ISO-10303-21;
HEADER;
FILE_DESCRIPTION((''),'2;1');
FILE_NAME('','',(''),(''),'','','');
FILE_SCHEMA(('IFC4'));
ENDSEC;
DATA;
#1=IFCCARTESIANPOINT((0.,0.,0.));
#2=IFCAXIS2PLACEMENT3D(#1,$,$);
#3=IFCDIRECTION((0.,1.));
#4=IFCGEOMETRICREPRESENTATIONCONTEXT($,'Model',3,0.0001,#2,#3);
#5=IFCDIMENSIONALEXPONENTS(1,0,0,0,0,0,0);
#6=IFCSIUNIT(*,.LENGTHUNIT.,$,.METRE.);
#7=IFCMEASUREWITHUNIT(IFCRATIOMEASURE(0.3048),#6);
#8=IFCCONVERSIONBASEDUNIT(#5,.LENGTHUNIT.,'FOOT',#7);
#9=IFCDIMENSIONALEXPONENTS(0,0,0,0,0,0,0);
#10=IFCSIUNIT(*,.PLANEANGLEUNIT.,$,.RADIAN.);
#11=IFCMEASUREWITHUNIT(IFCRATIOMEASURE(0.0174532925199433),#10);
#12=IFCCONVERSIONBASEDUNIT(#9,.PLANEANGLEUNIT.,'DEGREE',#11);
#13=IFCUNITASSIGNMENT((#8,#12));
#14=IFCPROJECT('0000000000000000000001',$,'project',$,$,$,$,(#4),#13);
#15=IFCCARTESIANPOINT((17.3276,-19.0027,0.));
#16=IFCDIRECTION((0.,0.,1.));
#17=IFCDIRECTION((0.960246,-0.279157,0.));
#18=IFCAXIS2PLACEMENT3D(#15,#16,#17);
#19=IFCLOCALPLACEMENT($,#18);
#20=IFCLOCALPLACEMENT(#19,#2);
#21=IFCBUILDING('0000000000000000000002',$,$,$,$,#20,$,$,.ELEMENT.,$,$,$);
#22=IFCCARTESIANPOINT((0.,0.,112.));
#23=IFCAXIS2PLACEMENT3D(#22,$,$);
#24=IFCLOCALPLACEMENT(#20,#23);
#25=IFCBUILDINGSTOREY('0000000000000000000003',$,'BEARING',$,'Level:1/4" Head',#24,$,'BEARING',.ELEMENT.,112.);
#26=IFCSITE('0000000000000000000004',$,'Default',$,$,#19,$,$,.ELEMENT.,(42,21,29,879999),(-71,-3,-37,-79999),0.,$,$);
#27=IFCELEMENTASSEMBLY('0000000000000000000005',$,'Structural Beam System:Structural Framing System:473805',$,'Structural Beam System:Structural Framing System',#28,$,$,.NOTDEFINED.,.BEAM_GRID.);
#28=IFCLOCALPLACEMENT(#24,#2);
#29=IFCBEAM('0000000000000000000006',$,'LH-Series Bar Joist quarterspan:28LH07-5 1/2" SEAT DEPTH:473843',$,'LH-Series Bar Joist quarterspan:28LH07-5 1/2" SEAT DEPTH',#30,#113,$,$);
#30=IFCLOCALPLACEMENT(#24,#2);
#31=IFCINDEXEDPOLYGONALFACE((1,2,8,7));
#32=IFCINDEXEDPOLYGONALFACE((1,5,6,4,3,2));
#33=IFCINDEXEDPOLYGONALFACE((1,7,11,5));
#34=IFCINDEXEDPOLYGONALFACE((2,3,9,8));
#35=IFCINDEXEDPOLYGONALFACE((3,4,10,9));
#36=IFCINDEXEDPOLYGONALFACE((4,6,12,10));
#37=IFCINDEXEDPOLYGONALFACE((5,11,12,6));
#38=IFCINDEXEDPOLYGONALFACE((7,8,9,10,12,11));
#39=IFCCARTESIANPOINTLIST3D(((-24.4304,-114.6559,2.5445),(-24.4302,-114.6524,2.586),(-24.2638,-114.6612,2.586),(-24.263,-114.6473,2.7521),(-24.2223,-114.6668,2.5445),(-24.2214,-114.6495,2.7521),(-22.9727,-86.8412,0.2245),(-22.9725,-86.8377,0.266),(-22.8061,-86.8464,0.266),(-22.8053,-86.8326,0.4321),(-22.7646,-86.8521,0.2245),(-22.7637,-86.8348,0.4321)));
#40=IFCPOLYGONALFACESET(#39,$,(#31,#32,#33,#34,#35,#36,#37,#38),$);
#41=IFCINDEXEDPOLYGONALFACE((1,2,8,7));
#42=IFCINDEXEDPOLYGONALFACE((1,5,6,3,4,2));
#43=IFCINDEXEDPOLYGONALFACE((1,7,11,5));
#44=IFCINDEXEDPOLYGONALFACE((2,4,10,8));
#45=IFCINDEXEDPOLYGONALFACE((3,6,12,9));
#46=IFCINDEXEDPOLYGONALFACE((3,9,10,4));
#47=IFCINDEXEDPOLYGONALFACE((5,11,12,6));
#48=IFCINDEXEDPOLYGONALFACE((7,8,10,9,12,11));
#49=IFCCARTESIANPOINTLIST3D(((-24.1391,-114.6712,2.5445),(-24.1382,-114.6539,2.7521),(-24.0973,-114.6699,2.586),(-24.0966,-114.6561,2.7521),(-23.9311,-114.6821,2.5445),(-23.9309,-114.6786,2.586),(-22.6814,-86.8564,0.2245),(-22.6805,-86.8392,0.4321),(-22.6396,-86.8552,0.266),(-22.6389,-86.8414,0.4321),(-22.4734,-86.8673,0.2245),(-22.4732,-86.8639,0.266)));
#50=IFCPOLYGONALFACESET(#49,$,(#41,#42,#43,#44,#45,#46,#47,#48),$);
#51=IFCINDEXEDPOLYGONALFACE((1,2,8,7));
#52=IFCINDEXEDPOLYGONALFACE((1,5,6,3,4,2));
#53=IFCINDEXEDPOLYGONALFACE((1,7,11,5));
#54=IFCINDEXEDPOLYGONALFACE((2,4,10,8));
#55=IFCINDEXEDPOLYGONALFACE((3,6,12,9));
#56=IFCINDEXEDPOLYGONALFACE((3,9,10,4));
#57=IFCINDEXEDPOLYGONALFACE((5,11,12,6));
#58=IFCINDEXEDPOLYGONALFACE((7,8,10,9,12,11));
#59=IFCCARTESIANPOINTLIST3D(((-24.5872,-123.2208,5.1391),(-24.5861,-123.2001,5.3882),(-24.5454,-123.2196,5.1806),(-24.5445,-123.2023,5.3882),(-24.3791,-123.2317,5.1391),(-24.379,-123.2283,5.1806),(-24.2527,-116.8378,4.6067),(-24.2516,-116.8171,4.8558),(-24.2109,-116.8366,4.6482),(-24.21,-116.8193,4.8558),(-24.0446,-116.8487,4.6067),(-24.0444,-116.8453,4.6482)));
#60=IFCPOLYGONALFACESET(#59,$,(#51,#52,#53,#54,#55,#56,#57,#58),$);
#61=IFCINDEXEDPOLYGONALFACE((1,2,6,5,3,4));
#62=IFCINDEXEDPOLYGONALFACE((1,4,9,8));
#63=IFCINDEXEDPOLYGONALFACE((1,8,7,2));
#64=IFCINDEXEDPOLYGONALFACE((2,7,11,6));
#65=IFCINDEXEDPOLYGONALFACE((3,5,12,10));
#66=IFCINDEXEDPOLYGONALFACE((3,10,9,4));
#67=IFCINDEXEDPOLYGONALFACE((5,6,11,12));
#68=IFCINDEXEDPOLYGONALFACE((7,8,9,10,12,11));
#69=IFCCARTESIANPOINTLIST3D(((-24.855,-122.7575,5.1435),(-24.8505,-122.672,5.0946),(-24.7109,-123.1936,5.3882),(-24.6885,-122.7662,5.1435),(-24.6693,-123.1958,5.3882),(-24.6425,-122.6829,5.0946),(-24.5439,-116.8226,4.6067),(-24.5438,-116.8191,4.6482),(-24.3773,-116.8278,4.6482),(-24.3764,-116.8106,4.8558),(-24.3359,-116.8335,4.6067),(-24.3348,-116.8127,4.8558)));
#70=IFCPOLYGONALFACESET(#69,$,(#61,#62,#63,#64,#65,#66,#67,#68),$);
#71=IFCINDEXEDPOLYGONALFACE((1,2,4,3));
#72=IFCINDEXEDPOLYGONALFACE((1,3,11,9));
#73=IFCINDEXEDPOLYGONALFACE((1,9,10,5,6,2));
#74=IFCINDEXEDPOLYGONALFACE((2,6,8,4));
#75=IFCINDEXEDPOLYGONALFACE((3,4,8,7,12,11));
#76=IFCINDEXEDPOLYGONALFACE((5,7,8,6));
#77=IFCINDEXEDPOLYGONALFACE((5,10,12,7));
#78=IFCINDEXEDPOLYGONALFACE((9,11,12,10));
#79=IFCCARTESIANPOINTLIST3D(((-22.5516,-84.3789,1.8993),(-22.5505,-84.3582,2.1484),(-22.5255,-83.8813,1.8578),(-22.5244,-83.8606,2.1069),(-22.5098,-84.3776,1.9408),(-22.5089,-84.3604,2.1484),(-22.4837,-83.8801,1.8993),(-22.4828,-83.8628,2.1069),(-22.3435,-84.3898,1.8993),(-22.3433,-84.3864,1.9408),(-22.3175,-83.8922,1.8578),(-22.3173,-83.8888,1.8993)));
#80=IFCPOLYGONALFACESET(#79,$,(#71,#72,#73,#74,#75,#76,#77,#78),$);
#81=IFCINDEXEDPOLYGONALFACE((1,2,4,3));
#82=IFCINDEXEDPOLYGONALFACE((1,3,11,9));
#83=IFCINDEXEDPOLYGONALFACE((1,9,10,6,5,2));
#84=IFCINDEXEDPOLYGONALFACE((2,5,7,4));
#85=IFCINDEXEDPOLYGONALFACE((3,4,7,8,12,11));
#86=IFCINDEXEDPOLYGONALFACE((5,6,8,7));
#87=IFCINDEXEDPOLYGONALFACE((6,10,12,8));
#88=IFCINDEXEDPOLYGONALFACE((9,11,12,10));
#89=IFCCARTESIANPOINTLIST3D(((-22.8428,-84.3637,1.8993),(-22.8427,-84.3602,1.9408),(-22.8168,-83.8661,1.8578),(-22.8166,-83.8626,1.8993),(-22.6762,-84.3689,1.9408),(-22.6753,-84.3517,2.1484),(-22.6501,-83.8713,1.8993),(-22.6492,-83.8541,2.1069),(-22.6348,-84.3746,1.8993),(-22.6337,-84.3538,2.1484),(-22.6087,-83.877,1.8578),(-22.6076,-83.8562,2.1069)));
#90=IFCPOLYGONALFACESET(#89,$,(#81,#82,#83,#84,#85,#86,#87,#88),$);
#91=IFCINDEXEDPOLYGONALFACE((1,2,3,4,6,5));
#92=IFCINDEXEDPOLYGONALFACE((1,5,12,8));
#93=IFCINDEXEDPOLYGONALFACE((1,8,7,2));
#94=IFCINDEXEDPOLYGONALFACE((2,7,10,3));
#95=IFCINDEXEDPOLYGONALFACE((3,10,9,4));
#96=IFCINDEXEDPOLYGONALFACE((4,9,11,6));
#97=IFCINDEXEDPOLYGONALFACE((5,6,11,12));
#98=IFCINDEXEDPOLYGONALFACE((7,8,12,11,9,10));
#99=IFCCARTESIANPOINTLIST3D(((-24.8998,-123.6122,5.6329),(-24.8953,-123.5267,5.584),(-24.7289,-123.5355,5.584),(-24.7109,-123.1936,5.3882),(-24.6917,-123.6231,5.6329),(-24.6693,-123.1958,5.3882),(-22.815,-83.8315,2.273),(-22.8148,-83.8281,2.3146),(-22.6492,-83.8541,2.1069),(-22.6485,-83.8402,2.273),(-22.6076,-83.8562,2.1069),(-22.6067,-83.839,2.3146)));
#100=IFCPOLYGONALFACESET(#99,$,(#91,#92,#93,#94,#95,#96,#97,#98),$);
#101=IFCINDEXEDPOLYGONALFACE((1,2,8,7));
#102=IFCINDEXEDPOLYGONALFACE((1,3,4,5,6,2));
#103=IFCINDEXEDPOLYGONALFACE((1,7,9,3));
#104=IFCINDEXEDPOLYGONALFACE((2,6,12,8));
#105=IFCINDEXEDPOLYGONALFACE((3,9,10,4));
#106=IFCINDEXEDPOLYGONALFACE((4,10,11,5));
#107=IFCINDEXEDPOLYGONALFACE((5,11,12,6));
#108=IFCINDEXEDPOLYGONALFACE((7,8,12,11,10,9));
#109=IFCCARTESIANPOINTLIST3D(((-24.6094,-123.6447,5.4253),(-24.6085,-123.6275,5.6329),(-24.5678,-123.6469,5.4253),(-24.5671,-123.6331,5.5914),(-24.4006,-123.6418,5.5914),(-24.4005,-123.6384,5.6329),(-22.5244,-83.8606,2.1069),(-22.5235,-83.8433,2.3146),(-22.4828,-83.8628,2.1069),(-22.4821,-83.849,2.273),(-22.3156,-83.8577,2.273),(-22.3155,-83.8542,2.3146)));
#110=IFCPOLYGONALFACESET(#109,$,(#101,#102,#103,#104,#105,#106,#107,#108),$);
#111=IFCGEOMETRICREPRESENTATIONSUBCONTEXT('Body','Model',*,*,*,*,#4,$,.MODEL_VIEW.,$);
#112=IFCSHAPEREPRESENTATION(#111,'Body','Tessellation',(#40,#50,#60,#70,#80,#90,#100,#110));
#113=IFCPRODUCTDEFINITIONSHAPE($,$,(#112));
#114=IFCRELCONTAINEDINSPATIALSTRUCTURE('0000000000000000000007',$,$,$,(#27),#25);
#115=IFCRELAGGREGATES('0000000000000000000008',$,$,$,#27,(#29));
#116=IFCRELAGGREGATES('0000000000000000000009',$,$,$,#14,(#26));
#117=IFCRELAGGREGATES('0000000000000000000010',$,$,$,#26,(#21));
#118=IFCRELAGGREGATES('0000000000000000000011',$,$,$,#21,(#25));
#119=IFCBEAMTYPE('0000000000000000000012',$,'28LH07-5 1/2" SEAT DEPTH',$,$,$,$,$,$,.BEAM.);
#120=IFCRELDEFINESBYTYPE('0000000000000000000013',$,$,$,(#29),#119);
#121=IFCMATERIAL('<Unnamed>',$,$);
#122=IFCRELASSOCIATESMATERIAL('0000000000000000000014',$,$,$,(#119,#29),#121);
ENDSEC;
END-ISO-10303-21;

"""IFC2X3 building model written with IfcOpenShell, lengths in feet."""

from ifc_helpers import new_model, entity, si_unit, converted_unit, direction, frame, origin, place, context, subcontext, project, spatial, polyline, outline, extrude, clip, halfspace, source, transform, mapped, material, type_object, type_shapes, element, aggregate, save


model = new_model("IFC2X3")

# Units and contexts
model_context = context("Model", 3, precision=0.0001, world=origin(), true_north=direction((0.0, 1.0)))
body_context = subcontext(model_context, "Body", "Model", "MODEL_VIEW")
ifc_project = project(units=[converted_unit("LENGTHUNIT", "FOOT", entity("IfcRatioMeasure", 0.3048), si_unit("LENGTHUNIT", "METRE"), dimensions=[1, 0, 0, 0, 0, 0, 0]), converted_unit("PLANEANGLEUNIT", "DEGREE", entity("IfcRatioMeasure", 0.0174532925199433), si_unit("PLANEANGLEUNIT", "RADIAN"), dimensions=[0, 0, 0, 0, 0, 0, 0])], contexts=[model_context])

# Site, building, storey
site_placement = place(None, frame((17.3276, -19.0027, 0.0), z_axis=(0.0, 0.0, 1.0), x_axis=(0.960246, -0.279157, 0.0)))
site = spatial("IfcSite", under=ifc_project, at=site_placement, Name="Default", CompositionType="ELEMENT", RefLatitude=(42, 21, 29, 879999), RefLongitude=(-71, -3, -37, -79999), RefElevation=0.0)
building_placement = place(site_placement, origin())
building = spatial("IfcBuilding", under=site, at=building_placement, CompositionType="ELEMENT")
storey_placement = place(building_placement, frame((0.0, 0.0, 112.0)))
storey = spatial("IfcBuildingStorey", under=building, at=storey_placement, Name="BEARING", ObjectType="Level:1/4\" Head", LongName="BEARING", CompositionType="ELEMENT", Elevation=112.0)

# Shared definitions
ifc_material_1 = material(Name="<Unnamed>")

# Element assembly, beam
assembly_placement = place(storey_placement, origin())
assembly = element("IfcElementAssembly", 1, at=assembly_placement, inside=storey, Name="Structural Beam System:Structural Framing System:473805", ObjectType="Structural Beam System:Structural Framing System", AssemblyPlace="NOTDEFINED", PredefinedType="BEAM_GRID")
beam_type_1 = type_object("IfcBeamType", Name="28LH07-5 1/2\" SEAT DEPTH", PredefinedType="BEAM", material=ifc_material_1)
shared_shape_1 = source(origin(), body_context, "Body", "SweptSolid", [
    extrude(outline(polyline([(-0.0833, -0.0833), (0.125, -0.0833), (0.125, -0.0417), (-0.0417, -0.0417), (-0.0417, 0.125), (-0.0833, 0.125), (-0.0833, -0.0833)])), frame((-22.8475, -86.8408, 112.3075), z_axis=(-0.052155, -0.995183, 0.083007), x_axis=(0.004344, 0.082893, 0.996549)), (0.0, 0.0, 1.0), 27.9493),
    extrude(outline(polyline([(-0.125, -0.0417), (-0.125, -0.0833), (0.0833, -0.0833), (0.0833, 0.125), (0.0417, 0.125), (0.0417, -0.0417), (-0.125, -0.0417)])), frame((-22.5978, -86.8539, 112.3075), z_axis=(0.052155, 0.995183, -0.083007), x_axis=(-0.99863, 0.052336, 0.0)), (0.0, 0.0, -1.0), 27.9493),
    extrude(outline(polyline([(-0.125, -0.0556), (-0.125, -0.0972), (0.0833, -0.0972), (0.0833, 0.1528), (0.0417, 0.1528), (0.0417, -0.0556), (-0.125, -0.0556)])), frame((-24.169, -116.8341, 116.7036), z_axis=(0.052155, 0.995183, -0.083007), x_axis=(-0.99863, 0.052336, 0.0)), (0.0, 0.0, -1.0), 6.4139),
    clip(extrude(outline(polyline([(-0.0972, -0.0833), (0.1528, -0.0833), (0.1528, -0.0417), (-0.0556, -0.0417), (-0.0556, 0.125), (-0.0972, 0.125), (-0.0972, -0.0833)])), frame((-24.4187, -116.821, 116.7036), z_axis=(-0.052155, -0.995183, 0.083007), x_axis=(0.004344, 0.082893, 0.996549)), (0.0, 0.0, 1.0), 6.4139), halfspace(frame((-64.572, -121.5331, 117.6329), z_axis=(-0.025979, -0.495709, -0.8681), x_axis=(0.99863, -0.052336, 0.0)), False)),
    extrude(outline(polyline([(-0.0972, -0.125), (-0.0556, -0.125), (-0.0556, 0.0417), (0.1528, 0.0417), (0.1528, 0.0833), (-0.0972, 0.0833), (-0.0972, -0.125)])), frame((-22.4419, -83.8776, 113.9547), z_axis=(-0.052155, -0.995183, 0.083007), x_axis=(0.004344, 0.082893, 0.996549)), (0.0, 0.0, 1.0), 0.5),
    extrude(outline(polyline([(-0.0972, -0.0833), (0.1528, -0.0833), (0.1528, -0.0417), (-0.0556, -0.0417), (-0.0556, 0.125), (-0.0972, 0.125), (-0.0972, -0.0833)])), frame((-22.6915, -83.8645, 113.9547), z_axis=(-0.052155, -0.995183, 0.083007), x_axis=(0.004344, 0.082893, 0.996549)), (0.0, 0.0, 1.0), 0.5),
    clip(extrude(outline(polyline([(-0.0833, -0.0833), (0.125, -0.0833), (0.125, -0.0417), (-0.0417, -0.0417), (-0.0417, 0.125), (-0.0833, 0.125), (-0.0833, -0.0833)])), frame((-22.6903, -83.8415, 114.2315), z_axis=(-0.052155, -0.995183, 0.083007), x_axis=(-0.99863, 0.052336, 0.0)), (0.0, 0.0, 1.0), 39.9767), halfspace(frame((-64.572, -121.5331, 117.6329), z_axis=(-0.025979, -0.495709, -0.8681), x_axis=(0.99863, -0.052336, 0.0)), False)),
    extrude(outline(polyline([(-0.125, -0.0833), (0.0833, -0.0833), (0.0833, 0.125), (0.0417, 0.125), (0.0417, -0.0417), (-0.125, -0.0417), (-0.125, -0.0833)])), frame((-22.4406, -83.8546, 114.2315), z_axis=(-0.052155, -0.995183, 0.083007), x_axis=(-0.99863, 0.052336, 0.0)), (0.0, 0.0, 1.0), 39.9767),
])
type_shapes(beam_type_1, [shared_shape_1])
beam_1_placement = place(assembly_placement, frame((0.0, 0.0, -112.0)))
beam_1 = element("IfcBeam", 2, at=beam_1_placement, type_object=beam_type_1, material=ifc_material_1, Name="LH-Series Bar Joist quarterspan:28LH07-5 1/2\" SEAT DEPTH:473843", ObjectType="LH-Series Bar Joist quarterspan:28LH07-5 1/2\" SEAT DEPTH", context=body_context, shape_type="MappedRepresentation", body=[
    mapped(shared_shape_1, transform((0.0, 0.0, 0.0), scale=1.0)),
])
aggregate(assembly, [beam_1])

save(model, "model.ifc")
